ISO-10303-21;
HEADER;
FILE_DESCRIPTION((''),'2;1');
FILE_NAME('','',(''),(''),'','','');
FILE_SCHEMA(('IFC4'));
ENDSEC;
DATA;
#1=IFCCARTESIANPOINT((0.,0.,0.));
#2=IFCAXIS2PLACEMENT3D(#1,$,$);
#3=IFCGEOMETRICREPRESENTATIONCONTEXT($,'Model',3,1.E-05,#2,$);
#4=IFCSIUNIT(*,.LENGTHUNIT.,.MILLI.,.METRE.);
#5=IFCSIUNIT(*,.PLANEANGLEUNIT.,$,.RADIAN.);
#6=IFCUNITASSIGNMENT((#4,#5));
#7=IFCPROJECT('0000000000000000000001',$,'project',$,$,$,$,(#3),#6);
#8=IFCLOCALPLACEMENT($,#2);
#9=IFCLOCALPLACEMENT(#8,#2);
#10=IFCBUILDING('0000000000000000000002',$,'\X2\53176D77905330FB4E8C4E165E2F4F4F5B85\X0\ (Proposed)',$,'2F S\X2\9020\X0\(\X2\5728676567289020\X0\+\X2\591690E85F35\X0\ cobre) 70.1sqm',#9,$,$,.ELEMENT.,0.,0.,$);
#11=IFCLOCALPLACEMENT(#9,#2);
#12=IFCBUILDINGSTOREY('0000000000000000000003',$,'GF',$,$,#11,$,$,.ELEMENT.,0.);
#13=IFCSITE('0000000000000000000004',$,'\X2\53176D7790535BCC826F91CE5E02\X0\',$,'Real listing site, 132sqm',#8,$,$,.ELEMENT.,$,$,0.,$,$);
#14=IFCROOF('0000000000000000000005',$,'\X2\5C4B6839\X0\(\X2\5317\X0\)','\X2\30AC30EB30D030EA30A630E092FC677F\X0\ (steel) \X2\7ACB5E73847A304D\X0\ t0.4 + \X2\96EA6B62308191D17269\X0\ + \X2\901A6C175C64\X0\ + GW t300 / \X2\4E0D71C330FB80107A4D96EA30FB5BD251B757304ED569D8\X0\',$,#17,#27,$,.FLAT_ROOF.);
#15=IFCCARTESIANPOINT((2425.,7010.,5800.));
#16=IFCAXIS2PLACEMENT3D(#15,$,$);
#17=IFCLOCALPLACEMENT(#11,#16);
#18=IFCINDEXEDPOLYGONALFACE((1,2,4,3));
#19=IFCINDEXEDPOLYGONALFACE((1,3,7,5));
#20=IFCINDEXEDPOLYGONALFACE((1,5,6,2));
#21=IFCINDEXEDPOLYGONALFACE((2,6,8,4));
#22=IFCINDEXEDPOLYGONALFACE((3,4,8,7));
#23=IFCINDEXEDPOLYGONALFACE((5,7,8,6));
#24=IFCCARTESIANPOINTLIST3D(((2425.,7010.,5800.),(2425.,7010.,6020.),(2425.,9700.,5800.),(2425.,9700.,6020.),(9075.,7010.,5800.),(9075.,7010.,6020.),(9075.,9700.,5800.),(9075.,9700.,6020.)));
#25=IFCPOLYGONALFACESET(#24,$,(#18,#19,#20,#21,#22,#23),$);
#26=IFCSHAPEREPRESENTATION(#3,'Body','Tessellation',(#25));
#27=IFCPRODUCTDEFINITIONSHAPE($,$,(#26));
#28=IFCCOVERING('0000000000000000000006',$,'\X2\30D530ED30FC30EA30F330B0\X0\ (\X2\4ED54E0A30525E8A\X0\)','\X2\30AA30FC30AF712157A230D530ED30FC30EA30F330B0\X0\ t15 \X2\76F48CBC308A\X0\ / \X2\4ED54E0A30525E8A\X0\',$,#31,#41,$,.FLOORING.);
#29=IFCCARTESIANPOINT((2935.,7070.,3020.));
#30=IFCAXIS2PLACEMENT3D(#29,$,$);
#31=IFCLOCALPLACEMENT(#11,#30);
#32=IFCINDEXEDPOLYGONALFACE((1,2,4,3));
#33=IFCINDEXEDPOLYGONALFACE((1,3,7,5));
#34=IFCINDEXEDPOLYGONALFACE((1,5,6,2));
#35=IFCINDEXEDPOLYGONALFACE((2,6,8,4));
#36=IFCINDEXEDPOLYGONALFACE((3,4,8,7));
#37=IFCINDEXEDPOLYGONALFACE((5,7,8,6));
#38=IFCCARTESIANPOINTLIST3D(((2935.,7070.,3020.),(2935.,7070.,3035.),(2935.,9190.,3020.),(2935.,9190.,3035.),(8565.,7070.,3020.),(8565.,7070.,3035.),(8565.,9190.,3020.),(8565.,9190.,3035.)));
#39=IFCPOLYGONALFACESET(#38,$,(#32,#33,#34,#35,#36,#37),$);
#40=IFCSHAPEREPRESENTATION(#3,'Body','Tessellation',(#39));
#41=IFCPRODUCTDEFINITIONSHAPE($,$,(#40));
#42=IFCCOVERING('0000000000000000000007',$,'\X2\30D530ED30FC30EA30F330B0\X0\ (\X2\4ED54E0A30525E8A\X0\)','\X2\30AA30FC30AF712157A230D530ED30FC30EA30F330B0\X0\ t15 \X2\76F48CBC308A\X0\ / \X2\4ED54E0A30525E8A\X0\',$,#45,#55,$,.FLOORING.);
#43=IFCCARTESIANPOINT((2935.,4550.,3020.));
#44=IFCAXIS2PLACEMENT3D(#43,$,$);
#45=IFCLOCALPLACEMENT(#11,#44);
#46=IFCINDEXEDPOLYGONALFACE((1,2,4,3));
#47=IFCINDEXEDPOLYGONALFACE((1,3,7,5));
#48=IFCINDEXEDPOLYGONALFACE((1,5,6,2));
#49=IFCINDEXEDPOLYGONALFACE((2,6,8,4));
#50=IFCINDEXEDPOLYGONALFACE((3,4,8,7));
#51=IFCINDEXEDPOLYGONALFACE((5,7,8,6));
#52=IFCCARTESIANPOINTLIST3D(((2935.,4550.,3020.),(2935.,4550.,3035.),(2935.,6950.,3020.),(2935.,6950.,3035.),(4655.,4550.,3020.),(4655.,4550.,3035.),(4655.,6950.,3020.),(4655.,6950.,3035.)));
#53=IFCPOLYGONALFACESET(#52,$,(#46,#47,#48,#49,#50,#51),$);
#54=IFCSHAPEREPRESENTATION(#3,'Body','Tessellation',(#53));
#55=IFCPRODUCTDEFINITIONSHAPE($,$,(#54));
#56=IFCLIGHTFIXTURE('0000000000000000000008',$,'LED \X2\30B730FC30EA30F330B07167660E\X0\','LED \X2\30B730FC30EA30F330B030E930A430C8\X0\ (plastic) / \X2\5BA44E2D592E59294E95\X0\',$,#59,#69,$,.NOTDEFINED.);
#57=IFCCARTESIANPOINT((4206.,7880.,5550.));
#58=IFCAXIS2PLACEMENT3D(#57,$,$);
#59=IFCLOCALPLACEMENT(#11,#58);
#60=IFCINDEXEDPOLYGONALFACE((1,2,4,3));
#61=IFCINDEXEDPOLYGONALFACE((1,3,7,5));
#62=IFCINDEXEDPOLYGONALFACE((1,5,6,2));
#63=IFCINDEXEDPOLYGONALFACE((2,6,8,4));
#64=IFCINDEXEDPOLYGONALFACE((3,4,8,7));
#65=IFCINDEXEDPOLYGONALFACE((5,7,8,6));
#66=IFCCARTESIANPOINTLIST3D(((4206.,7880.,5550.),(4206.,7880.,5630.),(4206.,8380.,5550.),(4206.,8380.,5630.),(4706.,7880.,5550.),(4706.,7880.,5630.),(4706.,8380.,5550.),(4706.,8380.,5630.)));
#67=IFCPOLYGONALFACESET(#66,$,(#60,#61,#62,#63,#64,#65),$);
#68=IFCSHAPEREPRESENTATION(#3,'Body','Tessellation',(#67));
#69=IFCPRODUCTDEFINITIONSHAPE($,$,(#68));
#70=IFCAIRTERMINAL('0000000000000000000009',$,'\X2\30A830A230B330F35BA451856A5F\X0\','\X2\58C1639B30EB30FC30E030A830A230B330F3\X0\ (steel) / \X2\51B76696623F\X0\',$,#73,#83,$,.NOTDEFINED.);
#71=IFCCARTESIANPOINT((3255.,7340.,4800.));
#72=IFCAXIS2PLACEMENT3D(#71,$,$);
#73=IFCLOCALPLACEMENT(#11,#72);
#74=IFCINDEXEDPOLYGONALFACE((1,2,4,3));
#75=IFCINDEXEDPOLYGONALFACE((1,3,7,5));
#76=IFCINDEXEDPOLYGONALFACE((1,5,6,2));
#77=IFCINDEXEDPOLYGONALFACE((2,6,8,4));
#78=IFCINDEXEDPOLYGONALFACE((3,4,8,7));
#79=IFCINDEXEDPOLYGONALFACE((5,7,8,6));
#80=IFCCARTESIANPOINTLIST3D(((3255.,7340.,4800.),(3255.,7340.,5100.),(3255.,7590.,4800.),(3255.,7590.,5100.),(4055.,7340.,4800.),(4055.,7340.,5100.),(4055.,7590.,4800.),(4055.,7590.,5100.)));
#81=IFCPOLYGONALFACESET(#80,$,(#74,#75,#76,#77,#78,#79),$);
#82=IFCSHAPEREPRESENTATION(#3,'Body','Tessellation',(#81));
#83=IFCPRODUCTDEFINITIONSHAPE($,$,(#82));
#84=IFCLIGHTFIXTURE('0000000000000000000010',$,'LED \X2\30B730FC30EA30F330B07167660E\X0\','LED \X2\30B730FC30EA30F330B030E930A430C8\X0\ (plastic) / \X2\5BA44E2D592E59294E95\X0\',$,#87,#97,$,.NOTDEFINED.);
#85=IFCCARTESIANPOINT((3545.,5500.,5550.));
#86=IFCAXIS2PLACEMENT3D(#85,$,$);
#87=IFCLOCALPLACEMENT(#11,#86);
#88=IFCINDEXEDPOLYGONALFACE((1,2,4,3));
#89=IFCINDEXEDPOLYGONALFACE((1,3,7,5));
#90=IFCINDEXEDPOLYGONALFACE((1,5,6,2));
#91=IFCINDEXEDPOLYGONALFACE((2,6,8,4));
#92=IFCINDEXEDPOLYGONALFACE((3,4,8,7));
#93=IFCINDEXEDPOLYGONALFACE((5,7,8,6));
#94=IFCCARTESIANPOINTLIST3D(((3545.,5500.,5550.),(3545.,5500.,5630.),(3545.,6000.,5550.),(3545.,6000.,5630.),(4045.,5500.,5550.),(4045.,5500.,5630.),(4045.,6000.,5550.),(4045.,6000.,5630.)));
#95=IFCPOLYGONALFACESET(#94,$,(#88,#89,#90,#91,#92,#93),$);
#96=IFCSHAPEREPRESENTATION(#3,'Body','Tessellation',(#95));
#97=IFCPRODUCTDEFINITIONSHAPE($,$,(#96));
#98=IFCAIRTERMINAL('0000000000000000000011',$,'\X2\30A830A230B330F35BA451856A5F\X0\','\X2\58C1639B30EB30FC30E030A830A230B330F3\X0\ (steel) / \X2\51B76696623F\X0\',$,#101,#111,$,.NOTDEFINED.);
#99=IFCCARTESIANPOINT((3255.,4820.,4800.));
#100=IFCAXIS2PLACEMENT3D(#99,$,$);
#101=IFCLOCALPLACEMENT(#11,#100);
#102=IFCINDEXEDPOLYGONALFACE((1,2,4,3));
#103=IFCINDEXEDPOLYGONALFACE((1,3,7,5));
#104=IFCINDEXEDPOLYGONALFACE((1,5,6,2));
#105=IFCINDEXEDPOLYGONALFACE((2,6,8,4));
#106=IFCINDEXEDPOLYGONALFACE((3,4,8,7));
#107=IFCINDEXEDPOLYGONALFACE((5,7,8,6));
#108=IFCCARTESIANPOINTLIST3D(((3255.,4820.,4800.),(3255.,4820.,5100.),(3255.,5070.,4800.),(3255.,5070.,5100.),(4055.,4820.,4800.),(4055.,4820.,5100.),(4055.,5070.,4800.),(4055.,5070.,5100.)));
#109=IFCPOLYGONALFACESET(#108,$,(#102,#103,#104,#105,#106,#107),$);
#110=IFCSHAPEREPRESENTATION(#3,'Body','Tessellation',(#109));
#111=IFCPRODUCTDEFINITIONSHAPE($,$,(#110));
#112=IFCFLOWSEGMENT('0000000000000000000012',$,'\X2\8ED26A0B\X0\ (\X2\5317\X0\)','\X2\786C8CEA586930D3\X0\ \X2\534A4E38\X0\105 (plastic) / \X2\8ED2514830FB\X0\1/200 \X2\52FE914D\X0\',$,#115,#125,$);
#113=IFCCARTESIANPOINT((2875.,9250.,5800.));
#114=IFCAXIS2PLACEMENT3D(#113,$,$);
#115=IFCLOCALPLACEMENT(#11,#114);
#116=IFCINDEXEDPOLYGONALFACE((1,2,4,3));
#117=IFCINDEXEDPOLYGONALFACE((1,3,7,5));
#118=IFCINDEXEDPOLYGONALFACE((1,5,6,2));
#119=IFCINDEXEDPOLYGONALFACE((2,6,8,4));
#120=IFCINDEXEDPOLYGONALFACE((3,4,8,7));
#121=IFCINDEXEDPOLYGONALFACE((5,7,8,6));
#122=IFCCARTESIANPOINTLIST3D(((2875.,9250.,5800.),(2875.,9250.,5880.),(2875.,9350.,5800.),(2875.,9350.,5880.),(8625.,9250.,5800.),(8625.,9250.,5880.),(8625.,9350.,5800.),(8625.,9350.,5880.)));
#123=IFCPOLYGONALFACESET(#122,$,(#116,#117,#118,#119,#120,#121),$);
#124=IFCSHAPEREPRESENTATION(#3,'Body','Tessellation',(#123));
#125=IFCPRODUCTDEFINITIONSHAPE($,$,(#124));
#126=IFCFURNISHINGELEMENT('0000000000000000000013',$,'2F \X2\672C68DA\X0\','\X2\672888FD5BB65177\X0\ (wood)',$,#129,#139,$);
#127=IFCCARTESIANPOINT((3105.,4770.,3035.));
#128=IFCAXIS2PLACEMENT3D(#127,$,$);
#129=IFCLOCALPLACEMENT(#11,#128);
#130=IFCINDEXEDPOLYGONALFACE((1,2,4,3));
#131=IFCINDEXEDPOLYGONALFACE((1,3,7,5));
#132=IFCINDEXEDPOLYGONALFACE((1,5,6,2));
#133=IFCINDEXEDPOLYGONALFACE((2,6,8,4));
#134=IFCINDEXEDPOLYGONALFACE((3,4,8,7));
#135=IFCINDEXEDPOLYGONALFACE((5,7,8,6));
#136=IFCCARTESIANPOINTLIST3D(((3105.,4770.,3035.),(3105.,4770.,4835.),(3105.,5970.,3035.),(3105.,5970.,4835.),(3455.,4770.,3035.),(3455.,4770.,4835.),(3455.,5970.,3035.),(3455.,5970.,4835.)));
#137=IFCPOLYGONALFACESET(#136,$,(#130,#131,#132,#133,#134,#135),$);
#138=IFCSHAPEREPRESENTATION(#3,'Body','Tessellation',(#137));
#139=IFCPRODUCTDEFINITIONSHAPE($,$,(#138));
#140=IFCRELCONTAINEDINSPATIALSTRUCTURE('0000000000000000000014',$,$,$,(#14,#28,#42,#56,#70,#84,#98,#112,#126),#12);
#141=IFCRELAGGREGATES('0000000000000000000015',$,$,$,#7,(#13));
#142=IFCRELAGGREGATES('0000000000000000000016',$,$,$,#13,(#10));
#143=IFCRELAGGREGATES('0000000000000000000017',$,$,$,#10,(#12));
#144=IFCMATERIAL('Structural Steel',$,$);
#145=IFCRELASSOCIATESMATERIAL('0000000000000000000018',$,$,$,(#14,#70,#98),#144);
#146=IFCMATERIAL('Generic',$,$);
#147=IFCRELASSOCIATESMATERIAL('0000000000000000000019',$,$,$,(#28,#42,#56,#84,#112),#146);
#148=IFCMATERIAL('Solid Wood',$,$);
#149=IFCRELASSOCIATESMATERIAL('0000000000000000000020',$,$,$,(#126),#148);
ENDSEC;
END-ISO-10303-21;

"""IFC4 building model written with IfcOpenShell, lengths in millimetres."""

from ifc_helpers import new_model, si_unit, frame, frame_2d, origin, place, context, project, spatial, rectangle, extrude, material, element, save


model = new_model("IFC4")

# Units and contexts
model_context = context("Model", 3, precision=1e-05, world=origin())
ifc_project = project(units=[si_unit("LENGTHUNIT", "METRE", prefix="MILLI"), si_unit("PLANEANGLEUNIT", "RADIAN")], contexts=[model_context])

# Site, building, storey
site_placement = place(None, origin())
site = spatial("IfcSite", under=ifc_project, at=site_placement, Name="北海道富良野市", ObjectType="Real listing site, 132sqm", CompositionType="ELEMENT", RefElevation=0.0)
building_placement = place(site_placement, origin())
building = spatial("IfcBuilding", under=site, at=building_placement, Name="北海道・二世帯住宅 (Proposed)", ObjectType="2F S造(在来木造+外部張 cobre) 70.1sqm", CompositionType="ELEMENT", ElevationOfRefHeight=0.0, ElevationOfTerrain=0.0)
storey_placement = place(building_placement, origin())
storey = spatial("IfcBuildingStorey", under=building, at=storey_placement, Name="GF", CompositionType="ELEMENT", Elevation=0.0)

# Shared definitions
ifc_material_1 = material(Name="Solid Wood")

# Roof
ifc_material_2 = material(Name="Structural Steel")
for number, where, name in (
    (1, (2425.0, 7010.0, 5800.0), "屋根(北)"),
):
    element("IfcRoof", number, at=place(storey_placement, frame(where)), inside=storey, material=ifc_material_2, Name=name, Description="ガルバリウム鋼板 (steel) 立平葺き t0.4 + 雪止め金物 + 通気層 + GW t300 / 不燃・耐積雪・寒冷地仕様", PredefinedType="FLAT_ROOF", context=model_context, shape_type="SweptSolid", body=[
        extrude(rectangle(XDim=6650.0, YDim=2690.0, at=frame_2d((3325.0, 1345.0))), frame((2425.0, 7010.0, 5800.0)), (0.0, 0.0, 1.0), 220.0),
    ])

# Coverings
ifc_material_3 = material(Name="Generic")
covering_1_placement = place(storey_placement, frame((2935.0, 7070.0, 3020.0)))
element("IfcCovering", 2, at=covering_1_placement, inside=storey, material=ifc_material_3, Name="フローリング (仕上げ床)", Description="オーク無垢フローリング t15 直貼り / 仕上げ床", PredefinedType="FLOORING", context=model_context, shape_type="SweptSolid", body=[
    extrude(rectangle(XDim=5630.0, YDim=2120.0, at=frame_2d((2815.0, 1060.0))), frame((2935.0, 7070.0, 3020.0)), (0.0, 0.0, 1.0), 15.0),
])
covering_2_placement = place(storey_placement, frame((2935.0, 4550.0, 3020.0)))
element("IfcCovering", 3, at=covering_2_placement, inside=storey, material=ifc_material_3, Name="フローリング (仕上げ床)", Description="オーク無垢フローリング t15 直貼り / 仕上げ床", PredefinedType="FLOORING", context=model_context, shape_type="SweptSolid", body=[
    extrude(rectangle(XDim=1720.0, YDim=2400.0, at=frame_2d((860.0, 1200.0))), frame((2935.0, 4550.0, 3020.0)), (0.0, 0.0, 1.0), 15.0),
])

# Light fixture
light_fixture_1_placement = place(storey_placement, frame((4206.0, 7880.0, 5550.0)))
element("IfcLightFixture", 4, at=light_fixture_1_placement, inside=storey, material=ifc_material_3, Name="LED シーリング照明", Description="LED シーリングライト (plastic) / 室中央天井", PredefinedType="NOTDEFINED", context=model_context, shape_type="SweptSolid", body=[
    extrude(rectangle(XDim=500.0, YDim=500.0, at=frame_2d((250.0, 250.0))), frame((4206.0, 7880.0, 5550.0)), (0.0, 0.0, 1.0), 80.0),
])

# Air terminal
air_terminal_1_placement = place(storey_placement, frame((3255.0, 7340.0, 4800.0)))
element("IfcAirTerminal", 5, at=air_terminal_1_placement, inside=storey, material=ifc_material_2, Name="エアコン室内機", Description="壁掛ルームエアコン (steel) / 冷暖房", PredefinedType="NOTDEFINED", context=model_context, shape_type="SweptSolid", body=[
    extrude(rectangle(XDim=800.0, YDim=250.0, at=frame_2d((400.0, 125.0))), frame((3255.0, 7340.0, 4800.0)), (0.0, 0.0, 1.0), 300.0),
])

# Light fixture
light_fixture_2_placement = place(storey_placement, frame((3545.0, 5500.0, 5550.0)))
element("IfcLightFixture", 6, at=light_fixture_2_placement, inside=storey, material=ifc_material_3, Name="LED シーリング照明", Description="LED シーリングライト (plastic) / 室中央天井", PredefinedType="NOTDEFINED", context=model_context, shape_type="SweptSolid", body=[
    extrude(rectangle(XDim=500.0, YDim=500.0, at=frame_2d((250.0, 250.0))), frame((3545.0, 5500.0, 5550.0)), (0.0, 0.0, 1.0), 80.0),
])

# Air terminal
air_terminal_2_placement = place(storey_placement, frame((3255.0, 4820.0, 4800.0)))
element("IfcAirTerminal", 7, at=air_terminal_2_placement, inside=storey, material=ifc_material_2, Name="エアコン室内機", Description="壁掛ルームエアコン (steel) / 冷暖房", PredefinedType="NOTDEFINED", context=model_context, shape_type="SweptSolid", body=[
    extrude(rectangle(XDim=800.0, YDim=250.0, at=frame_2d((400.0, 125.0))), frame((3255.0, 4820.0, 4800.0)), (0.0, 0.0, 1.0), 300.0),
])

# Flow segment
flow_segment_placement = place(storey_placement, frame((2875.0, 9250.0, 5800.0)))
element("IfcFlowSegment", 8, at=flow_segment_placement, inside=storey, material=ifc_material_3, Name="軒樋 (北)", Description="硬質塩ビ 半丸105 (plastic) / 軒先・1/200 勾配", context=model_context, shape_type="SweptSolid", body=[
    extrude(rectangle(XDim=5750.0, YDim=100.0, at=frame_2d((2875.0, 50.0))), frame((2875.0, 9250.0, 5800.0)), (0.0, 0.0, 1.0), 80.0),
])

# Furnishing element
furnishing_placement = place(storey_placement, frame((3105.0, 4770.0, 3035.0)))
element("IfcFurnishingElement", 9, at=furnishing_placement, inside=storey, material=ifc_material_1, Name="2F 本棚", Description="木製家具 (wood)", context=model_context, shape_type="SweptSolid", body=[
    extrude(rectangle(XDim=350.0, YDim=1200.0, at=frame_2d((175.0, 600.0))), frame((3105.0, 4770.0, 3035.0)), (0.0, 0.0, 1.0), 1800.0),
])

save(model, "model.ifc")
